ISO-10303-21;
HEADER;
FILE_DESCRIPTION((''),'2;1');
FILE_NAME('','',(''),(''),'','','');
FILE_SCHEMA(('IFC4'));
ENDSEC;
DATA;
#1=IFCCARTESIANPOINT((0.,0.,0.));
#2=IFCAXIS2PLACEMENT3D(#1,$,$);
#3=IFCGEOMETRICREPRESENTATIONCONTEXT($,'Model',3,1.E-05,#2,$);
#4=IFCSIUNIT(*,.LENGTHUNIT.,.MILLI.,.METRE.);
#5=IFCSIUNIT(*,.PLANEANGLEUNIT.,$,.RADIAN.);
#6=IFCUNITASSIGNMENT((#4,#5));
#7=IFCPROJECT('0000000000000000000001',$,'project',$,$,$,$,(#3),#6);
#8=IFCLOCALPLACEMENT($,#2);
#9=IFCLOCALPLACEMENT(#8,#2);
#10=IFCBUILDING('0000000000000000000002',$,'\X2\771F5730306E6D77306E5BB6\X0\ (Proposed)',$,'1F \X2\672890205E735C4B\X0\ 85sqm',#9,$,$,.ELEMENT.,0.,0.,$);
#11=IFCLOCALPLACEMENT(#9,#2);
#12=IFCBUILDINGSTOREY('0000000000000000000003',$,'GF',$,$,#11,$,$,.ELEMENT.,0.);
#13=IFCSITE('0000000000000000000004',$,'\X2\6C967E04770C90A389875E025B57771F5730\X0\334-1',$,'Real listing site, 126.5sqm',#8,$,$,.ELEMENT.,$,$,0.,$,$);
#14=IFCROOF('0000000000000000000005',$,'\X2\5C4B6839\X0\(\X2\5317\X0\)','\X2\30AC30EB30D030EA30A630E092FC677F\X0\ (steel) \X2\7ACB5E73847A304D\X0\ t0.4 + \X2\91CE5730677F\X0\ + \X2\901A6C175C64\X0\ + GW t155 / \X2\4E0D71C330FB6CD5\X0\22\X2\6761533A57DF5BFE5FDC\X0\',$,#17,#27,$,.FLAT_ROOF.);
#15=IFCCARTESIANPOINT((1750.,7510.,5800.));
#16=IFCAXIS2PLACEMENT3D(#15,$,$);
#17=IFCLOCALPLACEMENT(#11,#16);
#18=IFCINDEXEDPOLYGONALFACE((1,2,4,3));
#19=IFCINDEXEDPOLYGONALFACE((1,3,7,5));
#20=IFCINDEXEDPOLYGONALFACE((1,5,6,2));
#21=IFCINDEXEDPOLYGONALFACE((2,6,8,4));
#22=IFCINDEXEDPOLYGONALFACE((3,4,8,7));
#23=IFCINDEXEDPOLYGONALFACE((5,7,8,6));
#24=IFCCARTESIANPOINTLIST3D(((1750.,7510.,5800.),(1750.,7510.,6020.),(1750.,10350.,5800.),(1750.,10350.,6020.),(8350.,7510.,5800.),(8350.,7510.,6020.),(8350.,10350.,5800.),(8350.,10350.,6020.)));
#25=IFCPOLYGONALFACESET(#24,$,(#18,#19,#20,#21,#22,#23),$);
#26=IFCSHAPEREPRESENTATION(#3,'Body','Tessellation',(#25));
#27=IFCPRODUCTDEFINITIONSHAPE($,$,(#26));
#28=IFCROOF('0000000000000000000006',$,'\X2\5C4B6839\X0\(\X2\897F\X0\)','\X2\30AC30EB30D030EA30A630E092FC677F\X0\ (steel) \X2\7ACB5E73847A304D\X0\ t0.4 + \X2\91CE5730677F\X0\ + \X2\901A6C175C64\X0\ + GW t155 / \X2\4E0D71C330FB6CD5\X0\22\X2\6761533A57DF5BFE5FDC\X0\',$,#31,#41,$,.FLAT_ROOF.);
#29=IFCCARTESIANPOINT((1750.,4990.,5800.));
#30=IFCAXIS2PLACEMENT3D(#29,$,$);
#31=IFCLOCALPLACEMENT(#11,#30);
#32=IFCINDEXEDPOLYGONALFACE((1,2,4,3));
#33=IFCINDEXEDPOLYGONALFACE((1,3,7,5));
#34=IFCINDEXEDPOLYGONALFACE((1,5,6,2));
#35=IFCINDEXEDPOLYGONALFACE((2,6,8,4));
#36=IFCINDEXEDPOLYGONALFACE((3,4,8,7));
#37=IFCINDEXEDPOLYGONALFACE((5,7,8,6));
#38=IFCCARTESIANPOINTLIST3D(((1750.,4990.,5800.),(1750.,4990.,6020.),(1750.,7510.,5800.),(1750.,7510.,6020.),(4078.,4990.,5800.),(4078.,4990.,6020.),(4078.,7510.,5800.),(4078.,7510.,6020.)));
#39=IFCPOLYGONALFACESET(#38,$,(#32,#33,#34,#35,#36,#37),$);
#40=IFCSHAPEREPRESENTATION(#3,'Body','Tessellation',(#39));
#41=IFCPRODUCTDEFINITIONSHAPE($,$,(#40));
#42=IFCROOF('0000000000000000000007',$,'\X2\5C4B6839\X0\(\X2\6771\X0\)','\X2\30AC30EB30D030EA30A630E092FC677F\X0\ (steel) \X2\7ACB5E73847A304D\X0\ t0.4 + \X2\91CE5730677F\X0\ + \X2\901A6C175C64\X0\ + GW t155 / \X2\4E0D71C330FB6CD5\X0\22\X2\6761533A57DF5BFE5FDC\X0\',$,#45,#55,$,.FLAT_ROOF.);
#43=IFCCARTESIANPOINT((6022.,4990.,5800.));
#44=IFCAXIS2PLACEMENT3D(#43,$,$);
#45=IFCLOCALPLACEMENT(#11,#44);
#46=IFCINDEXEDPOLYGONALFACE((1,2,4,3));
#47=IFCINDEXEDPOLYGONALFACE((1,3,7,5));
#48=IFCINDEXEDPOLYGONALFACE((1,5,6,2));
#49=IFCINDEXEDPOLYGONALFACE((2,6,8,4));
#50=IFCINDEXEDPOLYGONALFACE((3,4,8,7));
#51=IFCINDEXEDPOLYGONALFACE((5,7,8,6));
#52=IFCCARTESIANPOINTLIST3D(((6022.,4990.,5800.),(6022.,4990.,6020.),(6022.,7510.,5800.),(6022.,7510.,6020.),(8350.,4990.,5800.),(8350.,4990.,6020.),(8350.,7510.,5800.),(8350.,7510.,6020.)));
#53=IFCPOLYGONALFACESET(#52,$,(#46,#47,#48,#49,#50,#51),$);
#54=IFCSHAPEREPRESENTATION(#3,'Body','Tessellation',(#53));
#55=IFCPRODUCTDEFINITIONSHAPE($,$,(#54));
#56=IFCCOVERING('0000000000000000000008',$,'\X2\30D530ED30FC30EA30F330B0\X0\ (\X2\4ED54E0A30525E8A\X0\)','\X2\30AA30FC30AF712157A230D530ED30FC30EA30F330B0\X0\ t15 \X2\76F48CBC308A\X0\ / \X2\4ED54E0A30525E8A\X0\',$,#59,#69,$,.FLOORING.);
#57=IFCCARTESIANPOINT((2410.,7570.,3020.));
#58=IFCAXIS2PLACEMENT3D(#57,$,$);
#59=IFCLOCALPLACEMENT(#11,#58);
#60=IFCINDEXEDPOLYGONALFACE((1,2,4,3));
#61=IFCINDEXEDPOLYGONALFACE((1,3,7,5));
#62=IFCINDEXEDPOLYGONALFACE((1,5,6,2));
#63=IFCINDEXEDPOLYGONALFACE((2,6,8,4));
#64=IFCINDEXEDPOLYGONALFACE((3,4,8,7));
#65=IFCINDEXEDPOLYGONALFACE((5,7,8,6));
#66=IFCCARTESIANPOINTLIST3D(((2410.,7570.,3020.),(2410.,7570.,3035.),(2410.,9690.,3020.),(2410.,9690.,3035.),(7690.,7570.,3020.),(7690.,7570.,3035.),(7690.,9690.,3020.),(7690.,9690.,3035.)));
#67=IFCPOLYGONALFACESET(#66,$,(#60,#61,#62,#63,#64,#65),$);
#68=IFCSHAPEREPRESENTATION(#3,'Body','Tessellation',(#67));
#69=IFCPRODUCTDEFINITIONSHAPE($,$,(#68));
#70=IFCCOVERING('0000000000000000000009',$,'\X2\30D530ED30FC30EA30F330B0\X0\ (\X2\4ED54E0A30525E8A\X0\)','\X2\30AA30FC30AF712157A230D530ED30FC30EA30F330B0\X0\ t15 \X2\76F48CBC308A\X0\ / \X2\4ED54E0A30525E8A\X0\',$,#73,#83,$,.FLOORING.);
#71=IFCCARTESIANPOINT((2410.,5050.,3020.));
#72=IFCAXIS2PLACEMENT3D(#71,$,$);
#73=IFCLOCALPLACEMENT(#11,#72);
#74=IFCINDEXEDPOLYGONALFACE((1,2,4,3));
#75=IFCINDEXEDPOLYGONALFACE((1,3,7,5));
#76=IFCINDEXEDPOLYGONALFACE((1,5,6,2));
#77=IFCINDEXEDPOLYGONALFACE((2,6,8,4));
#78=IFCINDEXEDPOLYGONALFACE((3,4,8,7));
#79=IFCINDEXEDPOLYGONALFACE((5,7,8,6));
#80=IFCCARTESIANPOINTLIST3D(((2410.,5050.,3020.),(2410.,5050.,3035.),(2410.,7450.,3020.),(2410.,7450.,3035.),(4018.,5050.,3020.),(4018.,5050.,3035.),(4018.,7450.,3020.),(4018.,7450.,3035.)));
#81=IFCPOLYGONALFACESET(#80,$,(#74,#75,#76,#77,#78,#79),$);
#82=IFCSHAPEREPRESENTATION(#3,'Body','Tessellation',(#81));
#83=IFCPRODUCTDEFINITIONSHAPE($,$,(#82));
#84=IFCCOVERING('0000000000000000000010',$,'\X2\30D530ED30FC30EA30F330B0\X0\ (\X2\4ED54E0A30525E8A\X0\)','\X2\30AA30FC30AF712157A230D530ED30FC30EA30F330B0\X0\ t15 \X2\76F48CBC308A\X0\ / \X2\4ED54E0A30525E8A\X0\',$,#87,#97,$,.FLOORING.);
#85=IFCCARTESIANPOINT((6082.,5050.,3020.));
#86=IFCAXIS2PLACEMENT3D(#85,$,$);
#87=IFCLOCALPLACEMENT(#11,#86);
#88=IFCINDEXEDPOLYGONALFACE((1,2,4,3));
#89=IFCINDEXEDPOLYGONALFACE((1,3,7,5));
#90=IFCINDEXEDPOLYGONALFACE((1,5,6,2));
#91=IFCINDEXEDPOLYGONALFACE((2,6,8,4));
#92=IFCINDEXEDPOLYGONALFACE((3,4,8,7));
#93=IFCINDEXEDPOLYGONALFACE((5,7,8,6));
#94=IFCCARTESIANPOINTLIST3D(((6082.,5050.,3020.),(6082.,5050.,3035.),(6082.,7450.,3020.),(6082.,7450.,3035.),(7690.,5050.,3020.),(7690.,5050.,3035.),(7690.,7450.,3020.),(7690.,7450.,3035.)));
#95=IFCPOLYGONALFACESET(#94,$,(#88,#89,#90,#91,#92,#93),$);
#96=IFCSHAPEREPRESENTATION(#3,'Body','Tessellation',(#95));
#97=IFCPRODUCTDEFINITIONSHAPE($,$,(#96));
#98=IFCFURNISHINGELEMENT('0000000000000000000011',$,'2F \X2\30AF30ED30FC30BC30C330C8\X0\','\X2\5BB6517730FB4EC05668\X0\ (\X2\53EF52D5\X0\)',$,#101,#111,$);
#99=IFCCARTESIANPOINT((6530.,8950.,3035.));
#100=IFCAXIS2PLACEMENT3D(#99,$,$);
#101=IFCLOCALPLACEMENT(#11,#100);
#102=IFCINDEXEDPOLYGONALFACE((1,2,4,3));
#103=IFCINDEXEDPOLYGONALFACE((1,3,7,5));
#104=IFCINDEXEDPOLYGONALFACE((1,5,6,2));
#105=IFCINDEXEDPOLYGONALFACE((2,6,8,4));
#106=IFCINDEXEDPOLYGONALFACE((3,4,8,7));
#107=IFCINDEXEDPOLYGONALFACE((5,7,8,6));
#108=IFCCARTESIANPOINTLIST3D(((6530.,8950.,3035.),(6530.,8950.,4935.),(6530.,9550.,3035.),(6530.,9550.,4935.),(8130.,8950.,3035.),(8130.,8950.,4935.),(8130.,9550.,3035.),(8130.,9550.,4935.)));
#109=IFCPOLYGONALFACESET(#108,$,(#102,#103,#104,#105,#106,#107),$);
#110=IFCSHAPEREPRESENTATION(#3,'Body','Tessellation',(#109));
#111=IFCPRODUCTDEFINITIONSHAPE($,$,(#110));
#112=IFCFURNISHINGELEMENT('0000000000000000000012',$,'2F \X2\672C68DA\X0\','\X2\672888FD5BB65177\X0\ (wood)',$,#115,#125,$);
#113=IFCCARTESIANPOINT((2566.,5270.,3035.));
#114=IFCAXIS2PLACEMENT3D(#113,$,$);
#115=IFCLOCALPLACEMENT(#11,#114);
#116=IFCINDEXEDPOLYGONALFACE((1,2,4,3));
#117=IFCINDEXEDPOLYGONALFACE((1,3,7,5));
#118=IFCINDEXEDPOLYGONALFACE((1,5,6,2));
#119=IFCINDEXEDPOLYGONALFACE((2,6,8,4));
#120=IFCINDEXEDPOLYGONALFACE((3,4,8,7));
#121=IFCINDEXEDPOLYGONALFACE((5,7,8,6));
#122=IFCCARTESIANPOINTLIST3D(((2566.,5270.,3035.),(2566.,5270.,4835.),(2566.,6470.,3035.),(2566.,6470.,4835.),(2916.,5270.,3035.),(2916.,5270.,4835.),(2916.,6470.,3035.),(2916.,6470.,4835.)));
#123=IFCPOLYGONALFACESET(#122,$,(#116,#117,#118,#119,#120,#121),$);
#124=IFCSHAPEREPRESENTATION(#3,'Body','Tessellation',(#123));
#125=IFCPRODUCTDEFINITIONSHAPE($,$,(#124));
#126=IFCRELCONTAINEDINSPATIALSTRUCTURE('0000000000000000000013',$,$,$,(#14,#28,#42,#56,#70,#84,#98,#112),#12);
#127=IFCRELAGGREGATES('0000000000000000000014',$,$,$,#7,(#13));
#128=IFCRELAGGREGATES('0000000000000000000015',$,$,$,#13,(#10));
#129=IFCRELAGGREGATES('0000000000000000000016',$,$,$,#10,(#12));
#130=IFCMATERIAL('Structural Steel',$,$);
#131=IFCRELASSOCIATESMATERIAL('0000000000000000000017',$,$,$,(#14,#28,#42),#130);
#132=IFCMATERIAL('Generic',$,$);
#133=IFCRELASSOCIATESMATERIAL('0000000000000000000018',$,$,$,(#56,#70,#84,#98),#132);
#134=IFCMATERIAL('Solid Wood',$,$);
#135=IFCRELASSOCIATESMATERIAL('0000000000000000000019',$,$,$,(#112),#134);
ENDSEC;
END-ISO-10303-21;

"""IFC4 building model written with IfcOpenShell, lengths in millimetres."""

from ifc_helpers import new_model, si_unit, frame, frame_2d, origin, place, context, project, spatial, rectangle, extrude, material, element, save


model = new_model("IFC4")

# Units and contexts
model_context = context("Model", 3, precision=1e-05, world=origin())
ifc_project = project(units=[si_unit("LENGTHUNIT", "METRE", prefix="MILLI"), si_unit("PLANEANGLEUNIT", "RADIAN")], contexts=[model_context])

# Site, building, storey
site_placement = place(None, origin())
site = spatial("IfcSite", under=ifc_project, at=site_placement, Name="沖縄県那覇市字真地334-1", ObjectType="Real listing site, 126.5sqm", CompositionType="ELEMENT", RefElevation=0.0)
building_placement = place(site_placement, origin())
building = spatial("IfcBuilding", under=site, at=building_placement, Name="真地の海の家 (Proposed)", ObjectType="1F 木造平屋 85sqm", CompositionType="ELEMENT", ElevationOfRefHeight=0.0, ElevationOfTerrain=0.0)
storey_placement = place(building_placement, origin())
storey = spatial("IfcBuildingStorey", under=building, at=storey_placement, Name="GF", CompositionType="ELEMENT", Elevation=0.0)

# Shared definitions
ifc_material_1 = material(Name="Solid Wood")

# Roofs
ifc_material_2 = material(Name="Structural Steel")
for number, where, name in (
    (1, (1750.0, 7510.0, 5800.0), "屋根(北)"),
):
    element("IfcRoof", number, at=place(storey_placement, frame(where)), inside=storey, material=ifc_material_2, Name=name, Description="ガルバリウム鋼板 (steel) 立平葺き t0.4 + 野地板 + 通気層 + GW t155 / 不燃・法22条区域対応", PredefinedType="FLAT_ROOF", context=model_context, shape_type="SweptSolid", body=[
        extrude(rectangle(XDim=6600.0, YDim=2840.0, at=frame_2d((3300.0, 1420.0))), frame((1750.0, 7510.0, 5800.0)), (0.0, 0.0, 1.0), 220.0),
    ])
roof_1_placement = place(storey_placement, frame((1750.0, 4990.0, 5800.0)))
element("IfcRoof", 2, at=roof_1_placement, inside=storey, material=ifc_material_2, Name="屋根(西)", Description="ガルバリウム鋼板 (steel) 立平葺き t0.4 + 野地板 + 通気層 + GW t155 / 不燃・法22条区域対応", PredefinedType="FLAT_ROOF", context=model_context, shape_type="SweptSolid", body=[
    extrude(rectangle(XDim=2328.0, YDim=2520.0, at=frame_2d((1164.0, 1260.0))), frame((1750.0, 4990.0, 5800.0)), (0.0, 0.0, 1.0), 220.0),
])
roof_2_placement = place(storey_placement, frame((6022.0, 4990.0, 5800.0)))
element("IfcRoof", 3, at=roof_2_placement, inside=storey, material=ifc_material_2, Name="屋根(東)", Description="ガルバリウム鋼板 (steel) 立平葺き t0.4 + 野地板 + 通気層 + GW t155 / 不燃・法22条区域対応", PredefinedType="FLAT_ROOF", context=model_context, shape_type="SweptSolid", body=[
    extrude(rectangle(XDim=2328.0, YDim=2520.0, at=frame_2d((1164.0, 1260.0))), frame((6022.0, 4990.0, 5800.0)), (0.0, 0.0, 1.0), 220.0),
])

# Coverings
ifc_material_3 = material(Name="Generic")
covering_1_placement = place(storey_placement, frame((2410.0, 7570.0, 3020.0)))
element("IfcCovering", 4, at=covering_1_placement, inside=storey, material=ifc_material_3, Name="フローリング (仕上げ床)", Description="オーク無垢フローリング t15 直貼り / 仕上げ床", PredefinedType="FLOORING", context=model_context, shape_type="SweptSolid", body=[
    extrude(rectangle(XDim=5280.0, YDim=2120.0, at=frame_2d((2640.0, 1060.0))), frame((2410.0, 7570.0, 3020.0)), (0.0, 0.0, 1.0), 15.0),
])
covering_2_placement = place(storey_placement, frame((2410.0, 5050.0, 3020.0)))
element("IfcCovering", 5, at=covering_2_placement, inside=storey, material=ifc_material_3, Name="フローリング (仕上げ床)", Description="オーク無垢フローリング t15 直貼り / 仕上げ床", PredefinedType="FLOORING", context=model_context, shape_type="SweptSolid", body=[
    extrude(rectangle(XDim=1608.0, YDim=2400.0, at=frame_2d((804.0, 1200.0))), frame((2410.0, 5050.0, 3020.0)), (0.0, 0.0, 1.0), 15.0),
])
covering_3_placement = place(storey_placement, frame((6082.0, 5050.0, 3020.0)))
element("IfcCovering", 6, at=covering_3_placement, inside=storey, material=ifc_material_3, Name="フローリング (仕上げ床)", Description="オーク無垢フローリング t15 直貼り / 仕上げ床", PredefinedType="FLOORING", context=model_context, shape_type="SweptSolid", body=[
    extrude(rectangle(XDim=1608.0, YDim=2400.0, at=frame_2d((804.0, 1200.0))), frame((6082.0, 5050.0, 3020.0)), (0.0, 0.0, 1.0), 15.0),
])

# Furnishing elements
furnishing_1_placement = place(storey_placement, frame((6530.0, 8950.0, 3035.0)))
element("IfcFurnishingElement", 7, at=furnishing_1_placement, inside=storey, material=ifc_material_3, Name="2F クローゼット", Description="家具・什器 (可動)", context=model_context, shape_type="SweptSolid", body=[
    extrude(rectangle(XDim=1600.0, YDim=600.0, at=frame_2d((800.0, 300.0))), frame((6530.0, 8950.0, 3035.0)), (0.0, 0.0, 1.0), 1900.0),
])
furnishing_2_placement = place(storey_placement, frame((2566.0, 5270.0, 3035.0)))
element("IfcFurnishingElement", 8, at=furnishing_2_placement, inside=storey, material=ifc_material_1, Name="2F 本棚", Description="木製家具 (wood)", context=model_context, shape_type="SweptSolid", body=[
    extrude(rectangle(XDim=350.0, YDim=1200.0, at=frame_2d((175.0, 600.0))), frame((2566.0, 5270.0, 3035.0)), (0.0, 0.0, 1.0), 1800.0),
])

save(model, "model.ifc")
